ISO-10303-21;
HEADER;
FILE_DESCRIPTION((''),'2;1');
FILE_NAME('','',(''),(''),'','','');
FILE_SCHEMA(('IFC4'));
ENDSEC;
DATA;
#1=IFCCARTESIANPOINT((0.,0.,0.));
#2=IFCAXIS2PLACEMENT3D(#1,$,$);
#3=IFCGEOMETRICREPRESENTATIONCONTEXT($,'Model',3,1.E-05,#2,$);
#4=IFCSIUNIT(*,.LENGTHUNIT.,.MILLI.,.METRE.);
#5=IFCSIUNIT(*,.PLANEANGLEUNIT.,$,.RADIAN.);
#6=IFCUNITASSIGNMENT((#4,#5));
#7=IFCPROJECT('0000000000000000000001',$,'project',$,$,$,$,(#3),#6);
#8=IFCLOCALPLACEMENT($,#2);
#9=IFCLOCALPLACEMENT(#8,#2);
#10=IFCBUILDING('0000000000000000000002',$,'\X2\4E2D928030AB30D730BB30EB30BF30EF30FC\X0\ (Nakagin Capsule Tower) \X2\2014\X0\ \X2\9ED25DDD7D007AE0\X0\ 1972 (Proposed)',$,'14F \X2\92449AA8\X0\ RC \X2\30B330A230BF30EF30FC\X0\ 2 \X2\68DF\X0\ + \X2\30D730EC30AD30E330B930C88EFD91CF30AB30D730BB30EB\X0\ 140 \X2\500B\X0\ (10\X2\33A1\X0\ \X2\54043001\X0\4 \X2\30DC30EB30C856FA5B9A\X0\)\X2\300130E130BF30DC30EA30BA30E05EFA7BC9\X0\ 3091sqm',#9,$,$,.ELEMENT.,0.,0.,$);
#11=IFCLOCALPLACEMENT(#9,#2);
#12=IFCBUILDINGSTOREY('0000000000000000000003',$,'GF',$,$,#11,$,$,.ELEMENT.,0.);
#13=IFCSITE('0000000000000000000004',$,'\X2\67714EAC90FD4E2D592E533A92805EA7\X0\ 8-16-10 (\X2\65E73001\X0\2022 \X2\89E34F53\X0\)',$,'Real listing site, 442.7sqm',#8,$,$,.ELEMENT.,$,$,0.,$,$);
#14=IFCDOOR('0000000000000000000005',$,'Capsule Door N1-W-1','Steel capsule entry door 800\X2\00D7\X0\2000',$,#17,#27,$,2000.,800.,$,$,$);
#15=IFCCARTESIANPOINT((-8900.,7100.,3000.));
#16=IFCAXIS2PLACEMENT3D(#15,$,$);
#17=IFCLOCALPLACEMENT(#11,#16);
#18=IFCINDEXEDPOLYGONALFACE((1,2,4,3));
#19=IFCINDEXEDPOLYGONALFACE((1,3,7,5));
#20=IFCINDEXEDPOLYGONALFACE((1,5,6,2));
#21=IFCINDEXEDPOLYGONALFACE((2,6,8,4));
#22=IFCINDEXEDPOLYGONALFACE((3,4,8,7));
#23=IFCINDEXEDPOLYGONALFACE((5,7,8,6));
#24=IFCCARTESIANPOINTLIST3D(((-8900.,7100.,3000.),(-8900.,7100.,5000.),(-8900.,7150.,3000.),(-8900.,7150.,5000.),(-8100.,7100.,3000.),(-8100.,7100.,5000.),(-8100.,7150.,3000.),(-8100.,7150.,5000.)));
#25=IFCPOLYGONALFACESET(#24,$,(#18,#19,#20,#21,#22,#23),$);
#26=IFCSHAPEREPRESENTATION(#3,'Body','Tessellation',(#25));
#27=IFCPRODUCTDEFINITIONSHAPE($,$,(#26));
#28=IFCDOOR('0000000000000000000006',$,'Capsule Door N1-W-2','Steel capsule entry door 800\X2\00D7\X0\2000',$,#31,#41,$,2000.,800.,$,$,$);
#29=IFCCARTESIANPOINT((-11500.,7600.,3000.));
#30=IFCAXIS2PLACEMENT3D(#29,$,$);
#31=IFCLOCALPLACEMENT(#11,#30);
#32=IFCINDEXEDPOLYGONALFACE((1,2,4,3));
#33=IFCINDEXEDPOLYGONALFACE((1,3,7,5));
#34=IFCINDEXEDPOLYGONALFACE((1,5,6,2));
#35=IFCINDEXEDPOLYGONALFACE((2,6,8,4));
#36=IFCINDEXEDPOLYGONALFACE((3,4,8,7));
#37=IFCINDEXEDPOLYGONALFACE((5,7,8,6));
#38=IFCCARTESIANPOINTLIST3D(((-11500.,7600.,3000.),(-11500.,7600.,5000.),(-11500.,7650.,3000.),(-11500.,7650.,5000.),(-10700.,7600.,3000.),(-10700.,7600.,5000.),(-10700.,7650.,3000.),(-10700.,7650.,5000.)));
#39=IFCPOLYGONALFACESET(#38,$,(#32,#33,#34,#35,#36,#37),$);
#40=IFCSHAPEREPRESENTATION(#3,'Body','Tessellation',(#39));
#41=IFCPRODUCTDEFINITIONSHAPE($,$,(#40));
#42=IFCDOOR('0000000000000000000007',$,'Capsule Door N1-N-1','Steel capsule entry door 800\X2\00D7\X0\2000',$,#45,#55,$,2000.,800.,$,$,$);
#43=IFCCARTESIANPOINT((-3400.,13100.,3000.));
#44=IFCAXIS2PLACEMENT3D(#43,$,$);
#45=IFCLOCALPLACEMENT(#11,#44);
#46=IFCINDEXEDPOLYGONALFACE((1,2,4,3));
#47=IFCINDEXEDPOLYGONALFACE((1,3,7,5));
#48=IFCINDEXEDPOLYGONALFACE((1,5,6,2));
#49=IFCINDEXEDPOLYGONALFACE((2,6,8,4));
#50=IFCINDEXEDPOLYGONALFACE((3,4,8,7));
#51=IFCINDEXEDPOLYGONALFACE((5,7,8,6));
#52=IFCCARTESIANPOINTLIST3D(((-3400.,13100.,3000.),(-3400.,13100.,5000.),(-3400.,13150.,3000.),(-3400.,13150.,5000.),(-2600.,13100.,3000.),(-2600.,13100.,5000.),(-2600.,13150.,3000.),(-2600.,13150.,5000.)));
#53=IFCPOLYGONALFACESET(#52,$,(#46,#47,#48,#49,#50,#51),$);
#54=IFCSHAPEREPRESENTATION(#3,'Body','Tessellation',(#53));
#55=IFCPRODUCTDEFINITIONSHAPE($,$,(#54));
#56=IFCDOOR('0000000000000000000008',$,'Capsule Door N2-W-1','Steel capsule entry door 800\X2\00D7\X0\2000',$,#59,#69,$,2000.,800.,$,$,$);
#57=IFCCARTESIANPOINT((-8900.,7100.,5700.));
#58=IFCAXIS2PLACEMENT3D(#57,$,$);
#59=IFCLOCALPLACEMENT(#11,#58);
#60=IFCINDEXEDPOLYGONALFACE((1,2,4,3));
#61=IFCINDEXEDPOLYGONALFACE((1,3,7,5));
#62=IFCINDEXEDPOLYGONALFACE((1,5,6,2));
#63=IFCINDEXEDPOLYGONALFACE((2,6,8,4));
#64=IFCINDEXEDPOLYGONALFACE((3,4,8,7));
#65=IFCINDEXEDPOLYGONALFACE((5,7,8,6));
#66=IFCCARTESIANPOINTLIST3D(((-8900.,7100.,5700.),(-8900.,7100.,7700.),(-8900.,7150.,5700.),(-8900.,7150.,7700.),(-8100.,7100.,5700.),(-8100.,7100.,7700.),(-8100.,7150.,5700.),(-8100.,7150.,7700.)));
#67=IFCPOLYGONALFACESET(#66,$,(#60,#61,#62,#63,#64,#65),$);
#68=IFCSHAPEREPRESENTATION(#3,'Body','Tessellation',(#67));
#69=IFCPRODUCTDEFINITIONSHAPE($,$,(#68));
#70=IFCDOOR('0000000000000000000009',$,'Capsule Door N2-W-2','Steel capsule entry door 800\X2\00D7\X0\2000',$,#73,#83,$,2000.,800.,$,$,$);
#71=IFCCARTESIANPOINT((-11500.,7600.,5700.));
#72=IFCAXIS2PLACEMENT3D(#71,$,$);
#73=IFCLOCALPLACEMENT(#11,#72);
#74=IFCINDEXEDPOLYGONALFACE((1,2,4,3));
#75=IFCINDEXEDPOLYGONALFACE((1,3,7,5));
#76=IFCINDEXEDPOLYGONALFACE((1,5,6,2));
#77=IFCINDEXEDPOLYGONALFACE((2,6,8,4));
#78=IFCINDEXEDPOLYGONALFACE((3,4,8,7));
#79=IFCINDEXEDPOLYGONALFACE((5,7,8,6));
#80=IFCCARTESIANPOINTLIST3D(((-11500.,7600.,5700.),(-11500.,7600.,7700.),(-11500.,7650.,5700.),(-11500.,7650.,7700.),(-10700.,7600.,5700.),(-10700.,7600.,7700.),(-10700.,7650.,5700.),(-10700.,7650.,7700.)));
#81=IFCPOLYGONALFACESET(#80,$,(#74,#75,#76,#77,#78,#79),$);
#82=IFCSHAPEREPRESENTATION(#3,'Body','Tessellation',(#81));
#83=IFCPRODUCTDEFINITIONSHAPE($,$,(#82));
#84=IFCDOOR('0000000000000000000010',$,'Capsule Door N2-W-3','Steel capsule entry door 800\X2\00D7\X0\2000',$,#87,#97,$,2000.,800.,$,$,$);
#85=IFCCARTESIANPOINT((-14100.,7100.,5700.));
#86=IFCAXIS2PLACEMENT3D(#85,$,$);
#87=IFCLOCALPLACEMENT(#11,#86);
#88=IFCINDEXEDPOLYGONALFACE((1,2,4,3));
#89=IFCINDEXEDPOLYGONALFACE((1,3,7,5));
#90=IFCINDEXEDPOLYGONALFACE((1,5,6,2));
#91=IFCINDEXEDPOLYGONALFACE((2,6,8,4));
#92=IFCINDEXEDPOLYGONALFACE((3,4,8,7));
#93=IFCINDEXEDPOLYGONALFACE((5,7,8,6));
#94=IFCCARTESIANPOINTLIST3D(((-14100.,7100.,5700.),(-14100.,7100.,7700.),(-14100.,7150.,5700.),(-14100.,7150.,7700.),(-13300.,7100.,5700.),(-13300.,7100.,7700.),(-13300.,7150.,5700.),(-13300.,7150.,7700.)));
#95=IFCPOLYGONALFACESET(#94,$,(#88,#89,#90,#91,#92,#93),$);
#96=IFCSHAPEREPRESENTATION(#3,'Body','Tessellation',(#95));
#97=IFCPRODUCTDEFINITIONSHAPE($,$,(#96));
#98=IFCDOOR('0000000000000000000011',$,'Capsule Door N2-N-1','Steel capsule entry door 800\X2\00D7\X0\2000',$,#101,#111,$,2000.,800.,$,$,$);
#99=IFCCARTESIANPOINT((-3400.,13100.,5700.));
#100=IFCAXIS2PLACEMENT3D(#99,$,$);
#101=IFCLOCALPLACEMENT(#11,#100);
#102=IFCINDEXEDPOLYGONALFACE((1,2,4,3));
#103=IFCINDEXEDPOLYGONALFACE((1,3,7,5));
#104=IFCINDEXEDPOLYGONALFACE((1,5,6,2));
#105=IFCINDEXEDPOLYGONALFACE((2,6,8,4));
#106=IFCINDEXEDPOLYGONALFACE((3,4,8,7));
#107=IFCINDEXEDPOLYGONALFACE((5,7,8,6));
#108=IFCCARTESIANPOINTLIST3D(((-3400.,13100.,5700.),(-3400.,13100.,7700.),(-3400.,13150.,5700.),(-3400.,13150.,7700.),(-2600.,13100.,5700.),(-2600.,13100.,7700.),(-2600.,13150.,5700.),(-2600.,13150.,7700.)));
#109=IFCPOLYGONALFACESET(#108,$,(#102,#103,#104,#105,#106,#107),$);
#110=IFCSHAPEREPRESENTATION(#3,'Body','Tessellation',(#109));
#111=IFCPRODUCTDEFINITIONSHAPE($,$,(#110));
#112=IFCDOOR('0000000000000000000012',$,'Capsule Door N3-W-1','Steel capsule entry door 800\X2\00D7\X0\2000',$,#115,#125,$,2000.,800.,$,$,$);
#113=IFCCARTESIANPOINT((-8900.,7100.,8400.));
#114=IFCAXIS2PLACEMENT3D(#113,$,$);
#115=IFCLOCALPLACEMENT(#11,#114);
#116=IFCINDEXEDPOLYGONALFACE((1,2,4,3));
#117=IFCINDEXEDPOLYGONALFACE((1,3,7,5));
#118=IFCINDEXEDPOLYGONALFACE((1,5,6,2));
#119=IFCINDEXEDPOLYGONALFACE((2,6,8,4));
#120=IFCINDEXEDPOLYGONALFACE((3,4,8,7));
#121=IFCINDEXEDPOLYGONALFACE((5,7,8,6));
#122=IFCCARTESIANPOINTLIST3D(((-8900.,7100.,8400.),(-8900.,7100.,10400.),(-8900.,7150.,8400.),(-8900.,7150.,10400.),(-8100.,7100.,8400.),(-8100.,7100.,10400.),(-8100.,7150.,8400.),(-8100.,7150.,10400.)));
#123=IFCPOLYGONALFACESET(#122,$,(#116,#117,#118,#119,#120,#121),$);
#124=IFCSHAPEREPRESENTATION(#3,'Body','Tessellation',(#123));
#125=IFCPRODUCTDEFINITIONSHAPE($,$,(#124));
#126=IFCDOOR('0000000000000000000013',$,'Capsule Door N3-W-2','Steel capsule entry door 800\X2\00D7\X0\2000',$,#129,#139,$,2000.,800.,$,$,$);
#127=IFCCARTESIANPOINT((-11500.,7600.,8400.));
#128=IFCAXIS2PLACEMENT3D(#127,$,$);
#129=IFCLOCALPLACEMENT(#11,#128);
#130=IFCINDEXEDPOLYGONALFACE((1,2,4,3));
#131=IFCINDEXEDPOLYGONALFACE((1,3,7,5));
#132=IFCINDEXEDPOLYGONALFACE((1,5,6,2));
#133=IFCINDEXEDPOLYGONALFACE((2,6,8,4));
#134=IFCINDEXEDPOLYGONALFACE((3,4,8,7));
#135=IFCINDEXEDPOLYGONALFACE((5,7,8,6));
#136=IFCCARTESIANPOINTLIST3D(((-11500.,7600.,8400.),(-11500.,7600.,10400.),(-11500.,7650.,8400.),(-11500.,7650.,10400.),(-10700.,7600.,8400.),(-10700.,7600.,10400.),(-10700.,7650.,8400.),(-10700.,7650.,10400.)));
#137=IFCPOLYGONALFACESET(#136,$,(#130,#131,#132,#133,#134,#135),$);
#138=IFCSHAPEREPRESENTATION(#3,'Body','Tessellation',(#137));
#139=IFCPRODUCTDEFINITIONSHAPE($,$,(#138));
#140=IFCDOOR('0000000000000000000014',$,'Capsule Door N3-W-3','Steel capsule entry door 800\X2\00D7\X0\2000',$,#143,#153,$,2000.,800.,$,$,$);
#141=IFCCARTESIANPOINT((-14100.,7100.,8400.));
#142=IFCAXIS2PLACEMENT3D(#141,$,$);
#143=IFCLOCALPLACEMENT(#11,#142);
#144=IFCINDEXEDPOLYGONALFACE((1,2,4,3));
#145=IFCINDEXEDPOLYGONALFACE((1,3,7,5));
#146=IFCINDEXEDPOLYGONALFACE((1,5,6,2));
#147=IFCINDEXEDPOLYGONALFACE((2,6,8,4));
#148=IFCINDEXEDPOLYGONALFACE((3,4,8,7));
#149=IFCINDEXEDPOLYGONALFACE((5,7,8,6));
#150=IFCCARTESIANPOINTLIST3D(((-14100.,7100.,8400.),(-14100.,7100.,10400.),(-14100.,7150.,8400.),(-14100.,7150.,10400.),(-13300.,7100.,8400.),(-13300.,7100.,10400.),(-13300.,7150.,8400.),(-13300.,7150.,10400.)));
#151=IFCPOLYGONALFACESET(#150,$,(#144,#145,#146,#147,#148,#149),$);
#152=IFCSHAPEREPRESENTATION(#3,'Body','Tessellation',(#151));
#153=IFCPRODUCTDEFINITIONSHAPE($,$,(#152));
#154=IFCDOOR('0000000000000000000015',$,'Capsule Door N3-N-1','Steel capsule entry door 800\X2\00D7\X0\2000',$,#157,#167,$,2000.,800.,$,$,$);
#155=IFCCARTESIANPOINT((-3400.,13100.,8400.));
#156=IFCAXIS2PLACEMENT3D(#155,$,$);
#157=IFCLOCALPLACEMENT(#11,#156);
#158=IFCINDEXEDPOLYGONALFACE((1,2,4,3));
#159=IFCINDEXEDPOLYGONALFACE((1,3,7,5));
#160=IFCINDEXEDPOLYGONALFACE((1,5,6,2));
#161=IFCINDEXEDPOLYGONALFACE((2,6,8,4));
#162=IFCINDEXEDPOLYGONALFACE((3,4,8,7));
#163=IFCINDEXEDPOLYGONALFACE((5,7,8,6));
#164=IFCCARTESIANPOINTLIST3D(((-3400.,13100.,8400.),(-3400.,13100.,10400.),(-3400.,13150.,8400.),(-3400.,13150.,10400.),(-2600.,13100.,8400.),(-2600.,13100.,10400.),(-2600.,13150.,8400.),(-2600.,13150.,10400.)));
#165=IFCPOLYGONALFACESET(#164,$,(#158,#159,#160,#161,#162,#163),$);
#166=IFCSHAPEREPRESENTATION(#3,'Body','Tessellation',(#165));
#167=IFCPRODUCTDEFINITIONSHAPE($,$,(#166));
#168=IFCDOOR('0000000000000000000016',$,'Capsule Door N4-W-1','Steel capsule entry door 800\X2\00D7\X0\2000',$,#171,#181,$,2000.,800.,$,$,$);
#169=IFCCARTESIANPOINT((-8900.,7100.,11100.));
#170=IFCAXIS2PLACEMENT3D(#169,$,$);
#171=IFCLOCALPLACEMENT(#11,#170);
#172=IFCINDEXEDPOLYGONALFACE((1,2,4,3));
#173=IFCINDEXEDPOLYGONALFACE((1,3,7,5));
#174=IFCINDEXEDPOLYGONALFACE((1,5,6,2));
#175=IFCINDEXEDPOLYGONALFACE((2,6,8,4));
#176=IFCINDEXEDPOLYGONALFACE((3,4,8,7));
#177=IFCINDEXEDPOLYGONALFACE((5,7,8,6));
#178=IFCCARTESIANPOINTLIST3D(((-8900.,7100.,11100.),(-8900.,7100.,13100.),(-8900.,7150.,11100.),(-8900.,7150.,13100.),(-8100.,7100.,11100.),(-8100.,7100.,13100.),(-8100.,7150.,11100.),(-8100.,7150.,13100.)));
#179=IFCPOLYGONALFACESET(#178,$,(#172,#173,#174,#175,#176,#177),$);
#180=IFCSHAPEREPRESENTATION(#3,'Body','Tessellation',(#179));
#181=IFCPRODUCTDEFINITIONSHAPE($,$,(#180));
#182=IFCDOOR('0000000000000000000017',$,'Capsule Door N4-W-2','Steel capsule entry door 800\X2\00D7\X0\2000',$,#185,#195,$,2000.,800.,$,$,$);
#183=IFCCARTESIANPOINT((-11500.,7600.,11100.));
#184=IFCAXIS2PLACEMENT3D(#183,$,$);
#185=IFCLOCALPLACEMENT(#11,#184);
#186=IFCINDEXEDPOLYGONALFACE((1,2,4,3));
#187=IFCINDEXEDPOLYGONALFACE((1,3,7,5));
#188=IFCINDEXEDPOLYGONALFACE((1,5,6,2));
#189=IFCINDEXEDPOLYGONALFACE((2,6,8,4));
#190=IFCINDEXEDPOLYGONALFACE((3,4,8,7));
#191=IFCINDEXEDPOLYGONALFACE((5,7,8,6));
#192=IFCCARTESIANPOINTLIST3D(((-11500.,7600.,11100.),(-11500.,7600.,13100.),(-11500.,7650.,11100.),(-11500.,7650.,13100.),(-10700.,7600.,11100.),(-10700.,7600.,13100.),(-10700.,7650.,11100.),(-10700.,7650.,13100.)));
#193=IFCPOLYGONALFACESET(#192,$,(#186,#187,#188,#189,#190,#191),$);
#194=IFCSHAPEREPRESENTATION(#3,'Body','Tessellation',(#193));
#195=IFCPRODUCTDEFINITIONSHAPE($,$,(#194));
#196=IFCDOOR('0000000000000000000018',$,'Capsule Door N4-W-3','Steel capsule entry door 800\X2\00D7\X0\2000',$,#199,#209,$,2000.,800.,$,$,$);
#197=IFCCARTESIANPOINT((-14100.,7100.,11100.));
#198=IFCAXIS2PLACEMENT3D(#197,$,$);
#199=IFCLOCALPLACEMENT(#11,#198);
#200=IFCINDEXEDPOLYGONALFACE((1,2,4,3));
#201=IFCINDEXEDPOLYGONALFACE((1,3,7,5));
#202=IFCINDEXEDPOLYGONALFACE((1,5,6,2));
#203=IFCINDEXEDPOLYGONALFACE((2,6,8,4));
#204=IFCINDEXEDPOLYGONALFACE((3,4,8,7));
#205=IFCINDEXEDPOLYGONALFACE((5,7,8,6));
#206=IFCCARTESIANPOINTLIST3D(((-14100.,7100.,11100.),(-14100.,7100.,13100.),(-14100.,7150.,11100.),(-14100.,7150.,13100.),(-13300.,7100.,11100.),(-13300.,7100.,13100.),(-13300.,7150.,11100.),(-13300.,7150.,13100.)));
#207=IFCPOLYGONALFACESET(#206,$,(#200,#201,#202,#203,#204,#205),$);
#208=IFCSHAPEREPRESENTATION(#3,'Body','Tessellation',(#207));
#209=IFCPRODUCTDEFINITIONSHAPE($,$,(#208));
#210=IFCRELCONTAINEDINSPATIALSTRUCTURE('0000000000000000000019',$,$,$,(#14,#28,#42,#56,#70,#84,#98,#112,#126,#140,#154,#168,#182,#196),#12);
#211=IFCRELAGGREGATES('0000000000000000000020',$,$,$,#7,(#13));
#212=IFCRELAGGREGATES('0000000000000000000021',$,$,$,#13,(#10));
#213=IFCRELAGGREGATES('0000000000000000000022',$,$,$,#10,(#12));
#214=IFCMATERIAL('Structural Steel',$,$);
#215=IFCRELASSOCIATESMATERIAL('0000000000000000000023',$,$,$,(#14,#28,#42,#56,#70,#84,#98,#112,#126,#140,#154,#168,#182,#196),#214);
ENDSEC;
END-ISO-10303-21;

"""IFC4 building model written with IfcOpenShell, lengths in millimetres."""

from ifc_helpers import new_model, si_unit, frame, frame_2d, origin, place, context, project, spatial, rectangle, extrude, material, element, save


model = new_model("IFC4")

# Units and contexts
model_context = context("Model", 3, precision=1e-05, world=origin())
ifc_project = project(units=[si_unit("LENGTHUNIT", "METRE", prefix="MILLI"), si_unit("PLANEANGLEUNIT", "RADIAN")], contexts=[model_context])

# Site, building, storey
site_placement = place(None, origin())
site = spatial("IfcSite", under=ifc_project, at=site_placement, Name="東京都中央区銀座 8-16-10 (旧、2022 解体)", ObjectType="Real listing site, 442.7sqm", CompositionType="ELEMENT", RefElevation=0.0)
building_placement = place(site_placement, origin())
building = spatial("IfcBuilding", under=site, at=building_placement, Name="中銀カプセルタワー (Nakagin Capsule Tower) — 黒川紀章 1972 (Proposed)", ObjectType="14F 鉄骨 RC コアタワー 2 棟 + プレキャスト軽量カプセル 140 個 (10㎡ 各、4 ボルト固定)、メタボリズム建築 3091sqm", CompositionType="ELEMENT", ElevationOfRefHeight=0.0, ElevationOfTerrain=0.0)
storey_placement = place(building_placement, origin())
storey = spatial("IfcBuildingStorey", under=building, at=storey_placement, Name="GF", CompositionType="ELEMENT", Elevation=0.0)

# Doors
ifc_material_1 = material(Name="Structural Steel")
door_1_placement = place(storey_placement, frame((-8900.0, 7100.0, 3000.0)))
element("IfcDoor", 1, at=door_1_placement, inside=storey, material=ifc_material_1, Name="Capsule Door N1-W-1", Description="Steel capsule entry door 800×2000", OverallHeight=2000.0, OverallWidth=800.0, context=model_context, shape_type="SweptSolid", body=[
    extrude(rectangle(XDim=800.0, YDim=50.0, at=frame_2d((400.0, 25.0))), frame((-8900.0, 7100.0, 3000.0)), (0.0, 0.0, 1.0), 2000.0),
])
door_2_placement = place(storey_placement, frame((-11500.0, 7600.0, 3000.0)))
element("IfcDoor", 2, at=door_2_placement, inside=storey, material=ifc_material_1, Name="Capsule Door N1-W-2", Description="Steel capsule entry door 800×2000", OverallHeight=2000.0, OverallWidth=800.0, context=model_context, shape_type="SweptSolid", body=[
    extrude(rectangle(XDim=800.0, YDim=50.0, at=frame_2d((400.0, 25.0))), frame((-11500.0, 7600.0, 3000.0)), (0.0, 0.0, 1.0), 2000.0),
])
door_3_placement = place(storey_placement, frame((-3400.0, 13100.0, 3000.0)))
element("IfcDoor", 3, at=door_3_placement, inside=storey, material=ifc_material_1, Name="Capsule Door N1-N-1", Description="Steel capsule entry door 800×2000", OverallHeight=2000.0, OverallWidth=800.0, context=model_context, shape_type="SweptSolid", body=[
    extrude(rectangle(XDim=800.0, YDim=50.0, at=frame_2d((400.0, 25.0))), frame((-3400.0, 13100.0, 3000.0)), (0.0, 0.0, 1.0), 2000.0),
])
door_4_placement = place(storey_placement, frame((-8900.0, 7100.0, 5700.0)))
element("IfcDoor", 4, at=door_4_placement, inside=storey, material=ifc_material_1, Name="Capsule Door N2-W-1", Description="Steel capsule entry door 800×2000", OverallHeight=2000.0, OverallWidth=800.0, context=model_context, shape_type="SweptSolid", body=[
    extrude(rectangle(XDim=800.0, YDim=50.0, at=frame_2d((400.0, 25.0))), frame((-8900.0, 7100.0, 5700.0)), (0.0, 0.0, 1.0), 2000.0),
])
door_5_placement = place(storey_placement, frame((-11500.0, 7600.0, 5700.0)))
element("IfcDoor", 5, at=door_5_placement, inside=storey, material=ifc_material_1, Name="Capsule Door N2-W-2", Description="Steel capsule entry door 800×2000", OverallHeight=2000.0, OverallWidth=800.0, context=model_context, shape_type="SweptSolid", body=[
    extrude(rectangle(XDim=800.0, YDim=50.0, at=frame_2d((400.0, 25.0))), frame((-11500.0, 7600.0, 5700.0)), (0.0, 0.0, 1.0), 2000.0),
])
door_6_placement = place(storey_placement, frame((-14100.0, 7100.0, 5700.0)))
element("IfcDoor", 6, at=door_6_placement, inside=storey, material=ifc_material_1, Name="Capsule Door N2-W-3", Description="Steel capsule entry door 800×2000", OverallHeight=2000.0, OverallWidth=800.0, context=model_context, shape_type="SweptSolid", body=[
    extrude(rectangle(XDim=800.0, YDim=50.0, at=frame_2d((400.0, 25.0))), frame((-14100.0, 7100.0, 5700.0)), (0.0, 0.0, 1.0), 2000.0),
])
door_7_placement = place(storey_placement, frame((-3400.0, 13100.0, 5700.0)))
element("IfcDoor", 7, at=door_7_placement, inside=storey, material=ifc_material_1, Name="Capsule Door N2-N-1", Description="Steel capsule entry door 800×2000", OverallHeight=2000.0, OverallWidth=800.0, context=model_context, shape_type="SweptSolid", body=[
    extrude(rectangle(XDim=800.0, YDim=50.0, at=frame_2d((400.0, 25.0))), frame((-3400.0, 13100.0, 5700.0)), (0.0, 0.0, 1.0), 2000.0),
])
door_8_placement = place(storey_placement, frame((-8900.0, 7100.0, 8400.0)))
element("IfcDoor", 8, at=door_8_placement, inside=storey, material=ifc_material_1, Name="Capsule Door N3-W-1", Description="Steel capsule entry door 800×2000", OverallHeight=2000.0, OverallWidth=800.0, context=model_context, shape_type="SweptSolid", body=[
    extrude(rectangle(XDim=800.0, YDim=50.0, at=frame_2d((400.0, 25.0))), frame((-8900.0, 7100.0, 8400.0)), (0.0, 0.0, 1.0), 2000.0),
])
door_9_placement = place(storey_placement, frame((-11500.0, 7600.0, 8400.0)))
element("IfcDoor", 9, at=door_9_placement, inside=storey, material=ifc_material_1, Name="Capsule Door N3-W-2", Description="Steel capsule entry door 800×2000", OverallHeight=2000.0, OverallWidth=800.0, context=model_context, shape_type="SweptSolid", body=[
    extrude(rectangle(XDim=800.0, YDim=50.0, at=frame_2d((400.0, 25.0))), frame((-11500.0, 7600.0, 8400.0)), (0.0, 0.0, 1.0), 2000.0),
])
door_10_placement = place(storey_placement, frame((-14100.0, 7100.0, 8400.0)))
element("IfcDoor", 10, at=door_10_placement, inside=storey, material=ifc_material_1, Name="Capsule Door N3-W-3", Description="Steel capsule entry door 800×2000", OverallHeight=2000.0, OverallWidth=800.0, context=model_context, shape_type="SweptSolid", body=[
    extrude(rectangle(XDim=800.0, YDim=50.0, at=frame_2d((400.0, 25.0))), frame((-14100.0, 7100.0, 8400.0)), (0.0, 0.0, 1.0), 2000.0),
])
door_11_placement = place(storey_placement, frame((-3400.0, 13100.0, 8400.0)))
element("IfcDoor", 11, at=door_11_placement, inside=storey, material=ifc_material_1, Name="Capsule Door N3-N-1", Description="Steel capsule entry door 800×2000", OverallHeight=2000.0, OverallWidth=800.0, context=model_context, shape_type="SweptSolid", body=[
    extrude(rectangle(XDim=800.0, YDim=50.0, at=frame_2d((400.0, 25.0))), frame((-3400.0, 13100.0, 8400.0)), (0.0, 0.0, 1.0), 2000.0),
])
door_12_placement = place(storey_placement, frame((-8900.0, 7100.0, 11100.0)))
element("IfcDoor", 12, at=door_12_placement, inside=storey, material=ifc_material_1, Name="Capsule Door N4-W-1", Description="Steel capsule entry door 800×2000", OverallHeight=2000.0, OverallWidth=800.0, context=model_context, shape_type="SweptSolid", body=[
    extrude(rectangle(XDim=800.0, YDim=50.0, at=frame_2d((400.0, 25.0))), frame((-8900.0, 7100.0, 11100.0)), (0.0, 0.0, 1.0), 2000.0),
])
door_13_placement = place(storey_placement, frame((-11500.0, 7600.0, 11100.0)))
element("IfcDoor", 13, at=door_13_placement, inside=storey, material=ifc_material_1, Name="Capsule Door N4-W-2", Description="Steel capsule entry door 800×2000", OverallHeight=2000.0, OverallWidth=800.0, context=model_context, shape_type="SweptSolid", body=[
    extrude(rectangle(XDim=800.0, YDim=50.0, at=frame_2d((400.0, 25.0))), frame((-11500.0, 7600.0, 11100.0)), (0.0, 0.0, 1.0), 2000.0),
])
door_14_placement = place(storey_placement, frame((-14100.0, 7100.0, 11100.0)))
element("IfcDoor", 14, at=door_14_placement, inside=storey, material=ifc_material_1, Name="Capsule Door N4-W-3", Description="Steel capsule entry door 800×2000", OverallHeight=2000.0, OverallWidth=800.0, context=model_context, shape_type="SweptSolid", body=[
    extrude(rectangle(XDim=800.0, YDim=50.0, at=frame_2d((400.0, 25.0))), frame((-14100.0, 7100.0, 11100.0)), (0.0, 0.0, 1.0), 2000.0),
])

save(model, "model.ifc")
